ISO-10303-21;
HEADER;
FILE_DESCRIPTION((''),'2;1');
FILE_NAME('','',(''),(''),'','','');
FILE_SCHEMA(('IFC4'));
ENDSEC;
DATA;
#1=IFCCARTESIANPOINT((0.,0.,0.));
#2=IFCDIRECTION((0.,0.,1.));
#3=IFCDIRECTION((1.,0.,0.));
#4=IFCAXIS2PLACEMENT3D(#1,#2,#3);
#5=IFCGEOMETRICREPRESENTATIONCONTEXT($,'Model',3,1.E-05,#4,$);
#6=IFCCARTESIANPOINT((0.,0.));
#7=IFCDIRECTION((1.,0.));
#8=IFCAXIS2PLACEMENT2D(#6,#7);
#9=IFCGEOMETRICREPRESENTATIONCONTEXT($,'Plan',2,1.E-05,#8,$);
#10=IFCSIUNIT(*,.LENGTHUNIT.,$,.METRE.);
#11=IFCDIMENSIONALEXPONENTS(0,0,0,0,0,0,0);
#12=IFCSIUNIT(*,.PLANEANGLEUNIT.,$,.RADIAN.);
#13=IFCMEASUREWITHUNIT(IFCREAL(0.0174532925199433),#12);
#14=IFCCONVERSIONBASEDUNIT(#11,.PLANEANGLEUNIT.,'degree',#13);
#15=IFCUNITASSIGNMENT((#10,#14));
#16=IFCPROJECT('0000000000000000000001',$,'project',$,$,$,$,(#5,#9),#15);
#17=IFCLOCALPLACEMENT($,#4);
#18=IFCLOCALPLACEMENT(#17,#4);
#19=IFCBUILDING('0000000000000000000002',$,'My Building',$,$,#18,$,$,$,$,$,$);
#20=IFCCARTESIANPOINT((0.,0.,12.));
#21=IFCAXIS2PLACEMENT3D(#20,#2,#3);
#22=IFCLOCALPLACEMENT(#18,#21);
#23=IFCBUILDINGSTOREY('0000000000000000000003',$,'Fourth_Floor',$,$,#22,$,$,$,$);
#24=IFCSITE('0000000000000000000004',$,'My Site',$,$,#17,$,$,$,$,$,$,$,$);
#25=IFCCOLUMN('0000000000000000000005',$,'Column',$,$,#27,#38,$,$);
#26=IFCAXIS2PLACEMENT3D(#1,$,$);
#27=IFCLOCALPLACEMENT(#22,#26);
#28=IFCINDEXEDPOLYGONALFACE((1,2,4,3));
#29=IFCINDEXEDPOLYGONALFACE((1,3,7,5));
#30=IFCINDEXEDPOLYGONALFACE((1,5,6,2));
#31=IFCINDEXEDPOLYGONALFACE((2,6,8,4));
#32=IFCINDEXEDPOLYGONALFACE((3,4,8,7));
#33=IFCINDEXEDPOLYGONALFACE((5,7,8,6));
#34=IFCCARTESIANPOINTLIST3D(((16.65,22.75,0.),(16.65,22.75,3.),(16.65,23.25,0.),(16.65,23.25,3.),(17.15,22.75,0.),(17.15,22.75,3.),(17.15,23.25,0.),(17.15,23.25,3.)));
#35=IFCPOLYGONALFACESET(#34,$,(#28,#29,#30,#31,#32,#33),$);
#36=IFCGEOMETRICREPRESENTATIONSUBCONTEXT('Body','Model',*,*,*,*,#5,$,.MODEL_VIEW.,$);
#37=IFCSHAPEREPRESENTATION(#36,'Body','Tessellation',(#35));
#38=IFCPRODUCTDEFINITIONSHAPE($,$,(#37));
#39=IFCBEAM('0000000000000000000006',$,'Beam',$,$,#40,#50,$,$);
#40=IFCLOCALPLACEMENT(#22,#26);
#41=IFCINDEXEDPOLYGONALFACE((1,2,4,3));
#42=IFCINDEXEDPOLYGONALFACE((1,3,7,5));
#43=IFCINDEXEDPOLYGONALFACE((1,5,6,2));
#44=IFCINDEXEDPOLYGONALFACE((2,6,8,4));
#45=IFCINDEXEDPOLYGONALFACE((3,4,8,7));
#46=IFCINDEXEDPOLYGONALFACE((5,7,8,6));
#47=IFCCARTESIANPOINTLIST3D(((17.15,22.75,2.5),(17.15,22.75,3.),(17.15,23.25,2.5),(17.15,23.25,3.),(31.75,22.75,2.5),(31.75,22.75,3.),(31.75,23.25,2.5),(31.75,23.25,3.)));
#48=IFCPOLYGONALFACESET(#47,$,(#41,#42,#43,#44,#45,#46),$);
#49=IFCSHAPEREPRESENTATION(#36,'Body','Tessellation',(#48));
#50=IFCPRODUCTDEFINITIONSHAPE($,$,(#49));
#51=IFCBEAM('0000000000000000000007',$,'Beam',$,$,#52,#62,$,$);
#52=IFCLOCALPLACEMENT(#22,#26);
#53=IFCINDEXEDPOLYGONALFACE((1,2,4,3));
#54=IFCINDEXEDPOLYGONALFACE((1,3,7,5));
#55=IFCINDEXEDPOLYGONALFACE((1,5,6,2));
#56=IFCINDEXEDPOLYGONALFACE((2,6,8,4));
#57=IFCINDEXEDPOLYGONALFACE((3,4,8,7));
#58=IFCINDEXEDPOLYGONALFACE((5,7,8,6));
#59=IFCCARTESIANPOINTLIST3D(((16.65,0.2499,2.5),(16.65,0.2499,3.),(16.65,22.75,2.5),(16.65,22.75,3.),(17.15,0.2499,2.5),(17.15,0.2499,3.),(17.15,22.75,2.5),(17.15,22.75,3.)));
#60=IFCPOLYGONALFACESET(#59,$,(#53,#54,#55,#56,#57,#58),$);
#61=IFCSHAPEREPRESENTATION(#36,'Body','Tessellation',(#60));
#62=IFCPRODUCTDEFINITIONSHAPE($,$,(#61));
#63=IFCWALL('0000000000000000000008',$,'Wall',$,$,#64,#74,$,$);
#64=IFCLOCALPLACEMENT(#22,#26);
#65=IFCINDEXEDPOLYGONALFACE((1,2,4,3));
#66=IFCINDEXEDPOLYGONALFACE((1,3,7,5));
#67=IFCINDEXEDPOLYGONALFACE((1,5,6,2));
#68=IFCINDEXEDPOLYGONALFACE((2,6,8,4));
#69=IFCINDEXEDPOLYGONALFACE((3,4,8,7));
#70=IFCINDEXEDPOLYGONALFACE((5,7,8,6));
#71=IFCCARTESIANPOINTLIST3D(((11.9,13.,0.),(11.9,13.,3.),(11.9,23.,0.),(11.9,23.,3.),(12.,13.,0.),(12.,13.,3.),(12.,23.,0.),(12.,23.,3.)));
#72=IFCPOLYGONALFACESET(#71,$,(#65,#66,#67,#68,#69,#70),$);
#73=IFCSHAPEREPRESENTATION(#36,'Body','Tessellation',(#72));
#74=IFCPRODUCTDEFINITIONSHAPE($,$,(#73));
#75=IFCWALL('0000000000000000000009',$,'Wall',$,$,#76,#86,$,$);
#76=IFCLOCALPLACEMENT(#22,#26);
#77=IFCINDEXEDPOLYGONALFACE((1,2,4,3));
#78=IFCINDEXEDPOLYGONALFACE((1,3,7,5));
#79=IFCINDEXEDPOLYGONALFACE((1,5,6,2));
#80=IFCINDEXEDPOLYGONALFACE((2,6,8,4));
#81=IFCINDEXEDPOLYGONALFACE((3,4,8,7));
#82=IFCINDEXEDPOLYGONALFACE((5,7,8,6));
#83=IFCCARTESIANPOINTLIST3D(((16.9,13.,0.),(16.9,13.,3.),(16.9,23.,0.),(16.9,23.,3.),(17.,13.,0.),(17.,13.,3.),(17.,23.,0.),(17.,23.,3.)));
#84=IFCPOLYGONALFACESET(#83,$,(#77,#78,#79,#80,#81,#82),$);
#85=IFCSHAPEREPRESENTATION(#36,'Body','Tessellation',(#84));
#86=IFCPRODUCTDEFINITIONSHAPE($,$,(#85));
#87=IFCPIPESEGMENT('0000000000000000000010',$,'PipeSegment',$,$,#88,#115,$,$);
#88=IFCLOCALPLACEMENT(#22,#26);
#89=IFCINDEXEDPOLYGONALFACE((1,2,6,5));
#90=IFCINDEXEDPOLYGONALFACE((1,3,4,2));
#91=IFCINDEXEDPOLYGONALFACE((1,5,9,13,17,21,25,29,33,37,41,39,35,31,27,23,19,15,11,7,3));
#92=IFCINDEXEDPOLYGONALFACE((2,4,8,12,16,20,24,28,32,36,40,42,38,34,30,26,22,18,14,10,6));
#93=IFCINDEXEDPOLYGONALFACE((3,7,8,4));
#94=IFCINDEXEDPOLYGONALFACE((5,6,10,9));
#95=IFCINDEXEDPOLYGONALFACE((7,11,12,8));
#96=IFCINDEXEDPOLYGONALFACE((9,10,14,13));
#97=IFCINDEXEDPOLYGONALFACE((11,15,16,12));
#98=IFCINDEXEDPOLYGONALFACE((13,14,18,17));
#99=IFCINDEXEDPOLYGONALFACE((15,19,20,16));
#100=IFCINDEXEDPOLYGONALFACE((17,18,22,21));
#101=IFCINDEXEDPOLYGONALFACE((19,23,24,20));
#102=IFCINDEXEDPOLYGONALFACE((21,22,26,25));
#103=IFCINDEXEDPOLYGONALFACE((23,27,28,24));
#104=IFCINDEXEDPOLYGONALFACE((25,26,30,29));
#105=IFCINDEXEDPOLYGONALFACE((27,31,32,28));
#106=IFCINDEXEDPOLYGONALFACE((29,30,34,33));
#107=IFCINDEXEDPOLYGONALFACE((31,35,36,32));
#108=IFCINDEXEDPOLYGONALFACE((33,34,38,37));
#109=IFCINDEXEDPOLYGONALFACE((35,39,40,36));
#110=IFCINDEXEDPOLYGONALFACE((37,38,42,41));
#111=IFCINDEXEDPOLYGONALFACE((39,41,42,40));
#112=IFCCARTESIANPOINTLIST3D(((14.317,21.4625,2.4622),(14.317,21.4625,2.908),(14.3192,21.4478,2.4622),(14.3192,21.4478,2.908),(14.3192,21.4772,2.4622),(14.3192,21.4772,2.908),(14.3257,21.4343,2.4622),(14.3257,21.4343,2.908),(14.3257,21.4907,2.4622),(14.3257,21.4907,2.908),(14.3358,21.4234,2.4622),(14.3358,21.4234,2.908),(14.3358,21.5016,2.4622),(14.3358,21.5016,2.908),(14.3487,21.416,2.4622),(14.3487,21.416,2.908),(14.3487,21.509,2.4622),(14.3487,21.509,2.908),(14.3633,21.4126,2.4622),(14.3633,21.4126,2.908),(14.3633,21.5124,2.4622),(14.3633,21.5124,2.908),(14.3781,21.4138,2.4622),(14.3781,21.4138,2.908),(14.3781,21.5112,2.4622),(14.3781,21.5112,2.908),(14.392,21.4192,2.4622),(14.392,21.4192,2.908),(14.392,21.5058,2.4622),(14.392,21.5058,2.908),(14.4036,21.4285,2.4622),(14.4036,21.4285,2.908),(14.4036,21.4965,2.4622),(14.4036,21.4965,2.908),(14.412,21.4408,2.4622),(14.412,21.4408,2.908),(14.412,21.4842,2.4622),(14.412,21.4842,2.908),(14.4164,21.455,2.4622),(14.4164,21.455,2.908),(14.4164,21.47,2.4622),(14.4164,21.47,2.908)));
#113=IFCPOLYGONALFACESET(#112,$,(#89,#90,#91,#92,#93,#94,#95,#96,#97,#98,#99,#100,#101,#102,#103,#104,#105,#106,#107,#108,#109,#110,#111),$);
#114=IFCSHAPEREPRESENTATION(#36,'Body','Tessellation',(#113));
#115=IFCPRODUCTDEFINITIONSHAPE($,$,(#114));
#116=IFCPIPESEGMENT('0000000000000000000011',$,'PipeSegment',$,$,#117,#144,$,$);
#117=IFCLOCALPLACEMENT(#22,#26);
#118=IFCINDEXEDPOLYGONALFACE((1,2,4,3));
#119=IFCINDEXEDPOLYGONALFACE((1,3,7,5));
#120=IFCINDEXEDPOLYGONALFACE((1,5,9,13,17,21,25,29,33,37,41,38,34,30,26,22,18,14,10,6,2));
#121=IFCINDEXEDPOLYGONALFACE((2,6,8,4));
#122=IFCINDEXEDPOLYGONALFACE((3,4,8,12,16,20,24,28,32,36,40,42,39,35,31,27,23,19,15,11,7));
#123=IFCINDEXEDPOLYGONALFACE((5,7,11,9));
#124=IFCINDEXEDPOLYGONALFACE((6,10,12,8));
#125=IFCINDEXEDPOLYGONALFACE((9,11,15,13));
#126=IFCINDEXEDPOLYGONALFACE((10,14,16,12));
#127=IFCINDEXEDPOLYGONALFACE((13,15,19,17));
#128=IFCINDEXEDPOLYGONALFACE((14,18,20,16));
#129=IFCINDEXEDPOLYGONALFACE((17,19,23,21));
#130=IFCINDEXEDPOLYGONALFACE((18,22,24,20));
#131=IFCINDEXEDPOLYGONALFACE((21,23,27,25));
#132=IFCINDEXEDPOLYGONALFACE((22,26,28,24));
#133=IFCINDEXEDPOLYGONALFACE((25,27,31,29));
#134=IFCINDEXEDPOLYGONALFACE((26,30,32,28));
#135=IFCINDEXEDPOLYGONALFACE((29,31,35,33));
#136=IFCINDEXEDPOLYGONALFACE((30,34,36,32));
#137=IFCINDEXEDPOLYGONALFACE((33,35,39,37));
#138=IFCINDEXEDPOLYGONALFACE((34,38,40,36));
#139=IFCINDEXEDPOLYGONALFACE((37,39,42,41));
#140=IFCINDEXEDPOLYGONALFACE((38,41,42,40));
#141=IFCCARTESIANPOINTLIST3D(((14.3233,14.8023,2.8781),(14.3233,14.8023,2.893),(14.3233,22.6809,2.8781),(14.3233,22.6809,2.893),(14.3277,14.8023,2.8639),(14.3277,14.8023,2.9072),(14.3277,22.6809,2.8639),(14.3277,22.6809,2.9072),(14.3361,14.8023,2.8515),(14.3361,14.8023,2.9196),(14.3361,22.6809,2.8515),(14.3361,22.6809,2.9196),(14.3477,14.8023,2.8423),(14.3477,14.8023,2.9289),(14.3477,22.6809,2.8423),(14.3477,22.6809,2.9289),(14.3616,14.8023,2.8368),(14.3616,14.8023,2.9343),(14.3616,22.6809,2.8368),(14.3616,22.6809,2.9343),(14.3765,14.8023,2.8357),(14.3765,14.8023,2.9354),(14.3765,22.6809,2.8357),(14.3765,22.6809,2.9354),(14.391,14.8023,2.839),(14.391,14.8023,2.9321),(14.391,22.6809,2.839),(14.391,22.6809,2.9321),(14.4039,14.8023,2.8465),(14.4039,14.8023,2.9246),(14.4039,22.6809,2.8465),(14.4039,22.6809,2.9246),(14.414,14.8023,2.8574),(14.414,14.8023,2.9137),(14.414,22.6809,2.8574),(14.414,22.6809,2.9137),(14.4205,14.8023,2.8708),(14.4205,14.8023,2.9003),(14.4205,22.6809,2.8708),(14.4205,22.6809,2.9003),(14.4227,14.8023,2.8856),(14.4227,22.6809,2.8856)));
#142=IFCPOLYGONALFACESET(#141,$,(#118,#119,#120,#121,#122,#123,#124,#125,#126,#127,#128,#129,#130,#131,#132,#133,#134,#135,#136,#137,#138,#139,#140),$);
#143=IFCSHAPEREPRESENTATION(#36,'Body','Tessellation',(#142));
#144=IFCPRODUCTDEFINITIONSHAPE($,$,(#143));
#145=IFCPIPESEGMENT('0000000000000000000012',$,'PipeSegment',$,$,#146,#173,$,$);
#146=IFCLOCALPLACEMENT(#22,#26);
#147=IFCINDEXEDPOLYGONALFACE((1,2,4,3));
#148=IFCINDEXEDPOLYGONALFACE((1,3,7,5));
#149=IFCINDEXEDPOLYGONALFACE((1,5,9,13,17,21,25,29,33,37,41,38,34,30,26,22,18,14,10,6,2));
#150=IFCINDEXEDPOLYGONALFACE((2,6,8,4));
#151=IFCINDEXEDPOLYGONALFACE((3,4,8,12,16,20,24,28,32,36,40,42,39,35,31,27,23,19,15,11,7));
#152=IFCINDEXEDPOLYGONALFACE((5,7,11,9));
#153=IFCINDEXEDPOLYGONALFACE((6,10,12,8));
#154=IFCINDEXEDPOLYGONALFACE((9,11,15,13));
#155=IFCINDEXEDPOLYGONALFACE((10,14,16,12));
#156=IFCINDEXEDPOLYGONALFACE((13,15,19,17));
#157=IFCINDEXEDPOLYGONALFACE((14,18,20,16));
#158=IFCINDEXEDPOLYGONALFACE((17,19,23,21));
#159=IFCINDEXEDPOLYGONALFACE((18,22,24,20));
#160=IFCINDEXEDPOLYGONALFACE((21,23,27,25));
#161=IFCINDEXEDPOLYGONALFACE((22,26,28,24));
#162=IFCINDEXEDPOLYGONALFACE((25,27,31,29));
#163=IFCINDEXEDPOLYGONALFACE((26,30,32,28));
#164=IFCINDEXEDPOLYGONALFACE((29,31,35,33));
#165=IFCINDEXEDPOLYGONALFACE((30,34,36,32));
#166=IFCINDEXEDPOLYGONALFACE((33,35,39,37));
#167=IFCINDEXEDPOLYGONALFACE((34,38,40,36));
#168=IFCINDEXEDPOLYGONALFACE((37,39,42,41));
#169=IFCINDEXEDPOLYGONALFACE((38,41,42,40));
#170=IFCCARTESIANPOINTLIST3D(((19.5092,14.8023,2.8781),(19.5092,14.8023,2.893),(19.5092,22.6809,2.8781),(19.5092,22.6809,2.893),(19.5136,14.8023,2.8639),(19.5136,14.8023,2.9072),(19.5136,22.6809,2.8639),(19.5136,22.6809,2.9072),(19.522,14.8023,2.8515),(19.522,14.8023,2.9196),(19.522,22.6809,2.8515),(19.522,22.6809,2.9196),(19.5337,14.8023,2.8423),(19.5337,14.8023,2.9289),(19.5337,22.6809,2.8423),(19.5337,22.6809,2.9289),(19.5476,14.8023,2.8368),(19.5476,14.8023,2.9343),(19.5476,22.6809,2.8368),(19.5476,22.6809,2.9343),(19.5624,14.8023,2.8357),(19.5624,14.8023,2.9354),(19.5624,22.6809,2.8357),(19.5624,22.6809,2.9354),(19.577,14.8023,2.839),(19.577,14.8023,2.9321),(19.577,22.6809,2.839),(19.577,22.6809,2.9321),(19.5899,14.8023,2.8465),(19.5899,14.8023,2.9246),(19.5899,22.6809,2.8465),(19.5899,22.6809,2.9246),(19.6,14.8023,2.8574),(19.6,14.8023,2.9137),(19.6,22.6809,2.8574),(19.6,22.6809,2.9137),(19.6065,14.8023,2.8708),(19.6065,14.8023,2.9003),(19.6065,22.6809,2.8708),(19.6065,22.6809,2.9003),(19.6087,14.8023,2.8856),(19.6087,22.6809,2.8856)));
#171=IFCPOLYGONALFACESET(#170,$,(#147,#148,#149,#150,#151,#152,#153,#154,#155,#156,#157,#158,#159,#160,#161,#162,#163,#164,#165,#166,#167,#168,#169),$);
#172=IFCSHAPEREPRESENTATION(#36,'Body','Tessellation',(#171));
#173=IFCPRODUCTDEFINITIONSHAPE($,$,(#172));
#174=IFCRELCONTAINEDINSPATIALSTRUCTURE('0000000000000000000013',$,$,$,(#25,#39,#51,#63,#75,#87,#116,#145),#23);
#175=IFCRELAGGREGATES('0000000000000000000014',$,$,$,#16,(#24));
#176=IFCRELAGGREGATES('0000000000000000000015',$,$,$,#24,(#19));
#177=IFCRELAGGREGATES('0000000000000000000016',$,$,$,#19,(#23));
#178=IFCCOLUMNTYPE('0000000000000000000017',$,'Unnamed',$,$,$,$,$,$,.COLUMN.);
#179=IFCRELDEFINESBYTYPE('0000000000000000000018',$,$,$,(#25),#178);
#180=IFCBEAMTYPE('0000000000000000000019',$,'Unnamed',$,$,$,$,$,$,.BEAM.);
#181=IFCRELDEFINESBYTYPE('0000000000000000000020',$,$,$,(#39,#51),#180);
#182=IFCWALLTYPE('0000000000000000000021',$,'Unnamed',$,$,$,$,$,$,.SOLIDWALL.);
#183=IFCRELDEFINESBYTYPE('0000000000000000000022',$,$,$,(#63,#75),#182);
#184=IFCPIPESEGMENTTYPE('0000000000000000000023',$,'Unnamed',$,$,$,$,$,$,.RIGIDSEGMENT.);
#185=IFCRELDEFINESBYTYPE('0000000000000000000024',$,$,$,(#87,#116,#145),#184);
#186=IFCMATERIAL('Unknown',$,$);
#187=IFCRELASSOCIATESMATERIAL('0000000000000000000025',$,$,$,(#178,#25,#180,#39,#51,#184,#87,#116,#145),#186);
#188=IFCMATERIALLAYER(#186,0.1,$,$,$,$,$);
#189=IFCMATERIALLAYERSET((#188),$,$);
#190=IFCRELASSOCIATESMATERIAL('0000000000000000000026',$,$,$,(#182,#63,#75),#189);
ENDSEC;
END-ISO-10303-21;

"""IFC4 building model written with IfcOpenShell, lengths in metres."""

from ifc_helpers import new_model, entity, si_unit, converted_unit, frame, origin_with_axes, origin_2d_with_axis, place, context, subcontext, project, spatial, line, indexed_curve, rectangle, circle, outline, extrude, material, layer, layer_set, layer_usage, material_profile, profile_set, profile_usage, type_object, element, save


model = new_model("IFC4")

# Units and contexts
model_context = context("Model", 3, precision=1e-05, world=origin_with_axes())
plan_context = context("Plan", 2, precision=1e-05, world=origin_2d_with_axis())
body_context = subcontext(model_context, "Body", "Model", "MODEL_VIEW")
ifc_project = project(units=[si_unit("LENGTHUNIT", "METRE"), converted_unit("PLANEANGLEUNIT", "degree", entity("IfcReal", 0.0174532925199433), si_unit("PLANEANGLEUNIT", "RADIAN"), dimensions=[0, 0, 0, 0, 0, 0, 0])], contexts=[model_context, plan_context])

# Site, building, storey
site_placement = place(None, origin_with_axes())
site = spatial("IfcSite", under=ifc_project, at=site_placement, Name="My Site")
building_placement = place(site_placement, origin_with_axes())
building = spatial("IfcBuilding", under=site, at=building_placement, Name="My Building")
storey_placement = place(building_placement, frame((0.0, 0.0, 12.0), z_axis=(0.0, 0.0, 1.0), x_axis=(1.0, 0.0, 0.0)))
storey = spatial("IfcBuildingStorey", under=building, at=storey_placement, Name="Fourth_Floor")

# Column
ifc_material = material(Name="Unknown")
ifc_material_profile_1 = material_profile(ifc_material, rectangle(XDim=0.5, YDim=0.5))
ifc_profile_set_1 = profile_set([ifc_material_profile_1])
ifc_profile_usage_1 = profile_usage(ifc_profile_set_1, cardinal=5)
column_type = type_object("IfcColumnType", Name="Unnamed", PredefinedType="COLUMN", material=ifc_profile_set_1)
column_placement = place(storey_placement, frame((16.9, 23.0, 0.0), z_axis=(0.0, 0.0, 1.0), x_axis=(1.0, 0.0, 0.0)))
element("IfcColumn", 1, at=column_placement, inside=storey, type_object=column_type, material=ifc_profile_usage_1, Name="Column", context=body_context, shape_type="SweptSolid", body=[
    extrude(rectangle(XDim=0.5, YDim=0.5), origin_with_axes(), (0.0, 0.0, 1.0), 3.0),
])

# Beams
ifc_material_profile_2 = material_profile(ifc_material, rectangle(XDim=0.5, YDim=0.5))
ifc_profile_set_2 = profile_set([ifc_material_profile_2])
ifc_profile_usage_2 = profile_usage(ifc_profile_set_2, cardinal=6)
beam_type = type_object("IfcBeamType", Name="Unnamed", PredefinedType="BEAM", material=ifc_profile_set_2)
beam_1_placement = place(storey_placement, frame((17.15, 22.75, 2.75), z_axis=(1.0, 0.0, 0.0), x_axis=(0.0, 1.0, 0.0)))
element("IfcBeam", 2, at=beam_1_placement, inside=storey, type_object=beam_type, material=ifc_profile_usage_2, Name="Beam", context=body_context, shape_type="SweptSolid", body=[
    extrude(rectangle(XDim=0.5, YDim=0.5), frame((0.25, 0.0, 0.0), z_axis=(0.0, 0.0, 1.0), x_axis=(1.0, 0.0, 0.0)), (0.0, 0.0, 1.0), 14.6),
])
ifc_profile_usage_3 = profile_usage(ifc_profile_set_2, cardinal=5)
beam_2_placement = place(storey_placement, frame((16.9, 22.75, 2.75), z_axis=(0.0, -1.0, 0.0), x_axis=(1.0, 0.0, 0.0)))
element("IfcBeam", 3, at=beam_2_placement, inside=storey, type_object=beam_type, material=ifc_profile_usage_3, Name="Beam", context=body_context, shape_type="SweptSolid", body=[
    extrude(rectangle(XDim=0.5, YDim=0.5), origin_with_axes(), (0.0, 0.0, 1.0), 22.5001),
])

# Walls
ifc_layer = layer(ifc_material, 0.1)
ifc_layer_set = layer_set([ifc_layer])
ifc_layer_usage_1 = layer_usage(ifc_layer_set, "AXIS2", "POSITIVE", 0.0)
wall_type = type_object("IfcWallType", Name="Unnamed", PredefinedType="SOLIDWALL", material=ifc_layer_set)
wall_1_placement = place(storey_placement, frame((11.9, 23.0, 0.0), z_axis=(0.0, 0.0, 1.0), x_axis=(0.0, -1.0, 0.0)))
element("IfcWall", 4, at=wall_1_placement, inside=storey, type_object=wall_type, material=ifc_layer_usage_1, Name="Wall", context=body_context, shape_type="SweptSolid", body=[
    extrude(outline(indexed_curve([(0.0, 0.0), (0.0, 0.1), (10.0, 0.1), (10.0, 0.0)], segments=[line(1, 2, 3, 4, 1)])), origin_with_axes(), (0.0, 0.0, 1.0), 3.0),
])
ifc_layer_usage_2 = layer_usage(ifc_layer_set, "AXIS2", "POSITIVE", 0.0)
wall_2_placement = place(storey_placement, frame((16.9, 23.0, 0.0), z_axis=(0.0, 0.0, 1.0), x_axis=(0.0, -1.0, 0.0)))
element("IfcWall", 5, at=wall_2_placement, inside=storey, type_object=wall_type, material=ifc_layer_usage_2, Name="Wall", context=body_context, shape_type="SweptSolid", body=[
    extrude(outline(indexed_curve([(0.0, 0.0), (0.0, 0.1), (10.0, 0.1), (10.0, 0.0)], segments=[line(1, 2, 3, 4, 1)])), origin_with_axes(), (0.0, 0.0, 1.0), 3.0),
])

# Pipe segments
ifc_material_profile_3 = material_profile(ifc_material, circle(Radius=0.05))
ifc_profile_set_3 = profile_set([ifc_material_profile_3])
ifc_profile_usage_4 = profile_usage(ifc_profile_set_3, cardinal=5)
pipe_segment_type = type_object("IfcPipeSegmentType", Name="Unnamed", PredefinedType="RIGIDSEGMENT", material=ifc_profile_set_3)
pipe_segment_1_placement = place(storey_placement, frame((14.367, 21.4625, 2.908), z_axis=(0.0, 0.0, -1.0), x_axis=(-1.0, 0.0, 0.0)))
element("IfcPipeSegment", 6, at=pipe_segment_1_placement, inside=storey, type_object=pipe_segment_type, material=ifc_profile_usage_4, Name="PipeSegment", context=body_context, shape_type="SweptSolid", body=[
    extrude(circle(Radius=0.05), origin_with_axes(), (0.0, 0.0, 1.0), 0.4458),
])
ifc_profile_usage_5 = profile_usage(ifc_profile_set_3, cardinal=5)
pipe_segment_2_placement = place(storey_placement, frame((14.3727, 22.6809, 2.8856), z_axis=(0.0, -1.0, 0.0), x_axis=(1.0, 0.0, 0.0)))
element("IfcPipeSegment", 7, at=pipe_segment_2_placement, inside=storey, type_object=pipe_segment_type, material=ifc_profile_usage_5, Name="PipeSegment", context=body_context, shape_type="SweptSolid", body=[
    extrude(circle(Radius=0.05), origin_with_axes(), (0.0, 0.0, 1.0), 7.8786),
])
ifc_profile_usage_6 = profile_usage(ifc_profile_set_3, cardinal=5)
pipe_segment_3_placement = place(storey_placement, frame((19.5587, 22.6809, 2.8856), z_axis=(0.0, -1.0, 0.0), x_axis=(1.0, 0.0, 0.0)))
element("IfcPipeSegment", 8, at=pipe_segment_3_placement, inside=storey, type_object=pipe_segment_type, material=ifc_profile_usage_6, Name="PipeSegment", context=body_context, shape_type="SweptSolid", body=[
    extrude(circle(Radius=0.05), origin_with_axes(), (0.0, 0.0, 1.0), 7.8786),
])

save(model, "model.ifc")
